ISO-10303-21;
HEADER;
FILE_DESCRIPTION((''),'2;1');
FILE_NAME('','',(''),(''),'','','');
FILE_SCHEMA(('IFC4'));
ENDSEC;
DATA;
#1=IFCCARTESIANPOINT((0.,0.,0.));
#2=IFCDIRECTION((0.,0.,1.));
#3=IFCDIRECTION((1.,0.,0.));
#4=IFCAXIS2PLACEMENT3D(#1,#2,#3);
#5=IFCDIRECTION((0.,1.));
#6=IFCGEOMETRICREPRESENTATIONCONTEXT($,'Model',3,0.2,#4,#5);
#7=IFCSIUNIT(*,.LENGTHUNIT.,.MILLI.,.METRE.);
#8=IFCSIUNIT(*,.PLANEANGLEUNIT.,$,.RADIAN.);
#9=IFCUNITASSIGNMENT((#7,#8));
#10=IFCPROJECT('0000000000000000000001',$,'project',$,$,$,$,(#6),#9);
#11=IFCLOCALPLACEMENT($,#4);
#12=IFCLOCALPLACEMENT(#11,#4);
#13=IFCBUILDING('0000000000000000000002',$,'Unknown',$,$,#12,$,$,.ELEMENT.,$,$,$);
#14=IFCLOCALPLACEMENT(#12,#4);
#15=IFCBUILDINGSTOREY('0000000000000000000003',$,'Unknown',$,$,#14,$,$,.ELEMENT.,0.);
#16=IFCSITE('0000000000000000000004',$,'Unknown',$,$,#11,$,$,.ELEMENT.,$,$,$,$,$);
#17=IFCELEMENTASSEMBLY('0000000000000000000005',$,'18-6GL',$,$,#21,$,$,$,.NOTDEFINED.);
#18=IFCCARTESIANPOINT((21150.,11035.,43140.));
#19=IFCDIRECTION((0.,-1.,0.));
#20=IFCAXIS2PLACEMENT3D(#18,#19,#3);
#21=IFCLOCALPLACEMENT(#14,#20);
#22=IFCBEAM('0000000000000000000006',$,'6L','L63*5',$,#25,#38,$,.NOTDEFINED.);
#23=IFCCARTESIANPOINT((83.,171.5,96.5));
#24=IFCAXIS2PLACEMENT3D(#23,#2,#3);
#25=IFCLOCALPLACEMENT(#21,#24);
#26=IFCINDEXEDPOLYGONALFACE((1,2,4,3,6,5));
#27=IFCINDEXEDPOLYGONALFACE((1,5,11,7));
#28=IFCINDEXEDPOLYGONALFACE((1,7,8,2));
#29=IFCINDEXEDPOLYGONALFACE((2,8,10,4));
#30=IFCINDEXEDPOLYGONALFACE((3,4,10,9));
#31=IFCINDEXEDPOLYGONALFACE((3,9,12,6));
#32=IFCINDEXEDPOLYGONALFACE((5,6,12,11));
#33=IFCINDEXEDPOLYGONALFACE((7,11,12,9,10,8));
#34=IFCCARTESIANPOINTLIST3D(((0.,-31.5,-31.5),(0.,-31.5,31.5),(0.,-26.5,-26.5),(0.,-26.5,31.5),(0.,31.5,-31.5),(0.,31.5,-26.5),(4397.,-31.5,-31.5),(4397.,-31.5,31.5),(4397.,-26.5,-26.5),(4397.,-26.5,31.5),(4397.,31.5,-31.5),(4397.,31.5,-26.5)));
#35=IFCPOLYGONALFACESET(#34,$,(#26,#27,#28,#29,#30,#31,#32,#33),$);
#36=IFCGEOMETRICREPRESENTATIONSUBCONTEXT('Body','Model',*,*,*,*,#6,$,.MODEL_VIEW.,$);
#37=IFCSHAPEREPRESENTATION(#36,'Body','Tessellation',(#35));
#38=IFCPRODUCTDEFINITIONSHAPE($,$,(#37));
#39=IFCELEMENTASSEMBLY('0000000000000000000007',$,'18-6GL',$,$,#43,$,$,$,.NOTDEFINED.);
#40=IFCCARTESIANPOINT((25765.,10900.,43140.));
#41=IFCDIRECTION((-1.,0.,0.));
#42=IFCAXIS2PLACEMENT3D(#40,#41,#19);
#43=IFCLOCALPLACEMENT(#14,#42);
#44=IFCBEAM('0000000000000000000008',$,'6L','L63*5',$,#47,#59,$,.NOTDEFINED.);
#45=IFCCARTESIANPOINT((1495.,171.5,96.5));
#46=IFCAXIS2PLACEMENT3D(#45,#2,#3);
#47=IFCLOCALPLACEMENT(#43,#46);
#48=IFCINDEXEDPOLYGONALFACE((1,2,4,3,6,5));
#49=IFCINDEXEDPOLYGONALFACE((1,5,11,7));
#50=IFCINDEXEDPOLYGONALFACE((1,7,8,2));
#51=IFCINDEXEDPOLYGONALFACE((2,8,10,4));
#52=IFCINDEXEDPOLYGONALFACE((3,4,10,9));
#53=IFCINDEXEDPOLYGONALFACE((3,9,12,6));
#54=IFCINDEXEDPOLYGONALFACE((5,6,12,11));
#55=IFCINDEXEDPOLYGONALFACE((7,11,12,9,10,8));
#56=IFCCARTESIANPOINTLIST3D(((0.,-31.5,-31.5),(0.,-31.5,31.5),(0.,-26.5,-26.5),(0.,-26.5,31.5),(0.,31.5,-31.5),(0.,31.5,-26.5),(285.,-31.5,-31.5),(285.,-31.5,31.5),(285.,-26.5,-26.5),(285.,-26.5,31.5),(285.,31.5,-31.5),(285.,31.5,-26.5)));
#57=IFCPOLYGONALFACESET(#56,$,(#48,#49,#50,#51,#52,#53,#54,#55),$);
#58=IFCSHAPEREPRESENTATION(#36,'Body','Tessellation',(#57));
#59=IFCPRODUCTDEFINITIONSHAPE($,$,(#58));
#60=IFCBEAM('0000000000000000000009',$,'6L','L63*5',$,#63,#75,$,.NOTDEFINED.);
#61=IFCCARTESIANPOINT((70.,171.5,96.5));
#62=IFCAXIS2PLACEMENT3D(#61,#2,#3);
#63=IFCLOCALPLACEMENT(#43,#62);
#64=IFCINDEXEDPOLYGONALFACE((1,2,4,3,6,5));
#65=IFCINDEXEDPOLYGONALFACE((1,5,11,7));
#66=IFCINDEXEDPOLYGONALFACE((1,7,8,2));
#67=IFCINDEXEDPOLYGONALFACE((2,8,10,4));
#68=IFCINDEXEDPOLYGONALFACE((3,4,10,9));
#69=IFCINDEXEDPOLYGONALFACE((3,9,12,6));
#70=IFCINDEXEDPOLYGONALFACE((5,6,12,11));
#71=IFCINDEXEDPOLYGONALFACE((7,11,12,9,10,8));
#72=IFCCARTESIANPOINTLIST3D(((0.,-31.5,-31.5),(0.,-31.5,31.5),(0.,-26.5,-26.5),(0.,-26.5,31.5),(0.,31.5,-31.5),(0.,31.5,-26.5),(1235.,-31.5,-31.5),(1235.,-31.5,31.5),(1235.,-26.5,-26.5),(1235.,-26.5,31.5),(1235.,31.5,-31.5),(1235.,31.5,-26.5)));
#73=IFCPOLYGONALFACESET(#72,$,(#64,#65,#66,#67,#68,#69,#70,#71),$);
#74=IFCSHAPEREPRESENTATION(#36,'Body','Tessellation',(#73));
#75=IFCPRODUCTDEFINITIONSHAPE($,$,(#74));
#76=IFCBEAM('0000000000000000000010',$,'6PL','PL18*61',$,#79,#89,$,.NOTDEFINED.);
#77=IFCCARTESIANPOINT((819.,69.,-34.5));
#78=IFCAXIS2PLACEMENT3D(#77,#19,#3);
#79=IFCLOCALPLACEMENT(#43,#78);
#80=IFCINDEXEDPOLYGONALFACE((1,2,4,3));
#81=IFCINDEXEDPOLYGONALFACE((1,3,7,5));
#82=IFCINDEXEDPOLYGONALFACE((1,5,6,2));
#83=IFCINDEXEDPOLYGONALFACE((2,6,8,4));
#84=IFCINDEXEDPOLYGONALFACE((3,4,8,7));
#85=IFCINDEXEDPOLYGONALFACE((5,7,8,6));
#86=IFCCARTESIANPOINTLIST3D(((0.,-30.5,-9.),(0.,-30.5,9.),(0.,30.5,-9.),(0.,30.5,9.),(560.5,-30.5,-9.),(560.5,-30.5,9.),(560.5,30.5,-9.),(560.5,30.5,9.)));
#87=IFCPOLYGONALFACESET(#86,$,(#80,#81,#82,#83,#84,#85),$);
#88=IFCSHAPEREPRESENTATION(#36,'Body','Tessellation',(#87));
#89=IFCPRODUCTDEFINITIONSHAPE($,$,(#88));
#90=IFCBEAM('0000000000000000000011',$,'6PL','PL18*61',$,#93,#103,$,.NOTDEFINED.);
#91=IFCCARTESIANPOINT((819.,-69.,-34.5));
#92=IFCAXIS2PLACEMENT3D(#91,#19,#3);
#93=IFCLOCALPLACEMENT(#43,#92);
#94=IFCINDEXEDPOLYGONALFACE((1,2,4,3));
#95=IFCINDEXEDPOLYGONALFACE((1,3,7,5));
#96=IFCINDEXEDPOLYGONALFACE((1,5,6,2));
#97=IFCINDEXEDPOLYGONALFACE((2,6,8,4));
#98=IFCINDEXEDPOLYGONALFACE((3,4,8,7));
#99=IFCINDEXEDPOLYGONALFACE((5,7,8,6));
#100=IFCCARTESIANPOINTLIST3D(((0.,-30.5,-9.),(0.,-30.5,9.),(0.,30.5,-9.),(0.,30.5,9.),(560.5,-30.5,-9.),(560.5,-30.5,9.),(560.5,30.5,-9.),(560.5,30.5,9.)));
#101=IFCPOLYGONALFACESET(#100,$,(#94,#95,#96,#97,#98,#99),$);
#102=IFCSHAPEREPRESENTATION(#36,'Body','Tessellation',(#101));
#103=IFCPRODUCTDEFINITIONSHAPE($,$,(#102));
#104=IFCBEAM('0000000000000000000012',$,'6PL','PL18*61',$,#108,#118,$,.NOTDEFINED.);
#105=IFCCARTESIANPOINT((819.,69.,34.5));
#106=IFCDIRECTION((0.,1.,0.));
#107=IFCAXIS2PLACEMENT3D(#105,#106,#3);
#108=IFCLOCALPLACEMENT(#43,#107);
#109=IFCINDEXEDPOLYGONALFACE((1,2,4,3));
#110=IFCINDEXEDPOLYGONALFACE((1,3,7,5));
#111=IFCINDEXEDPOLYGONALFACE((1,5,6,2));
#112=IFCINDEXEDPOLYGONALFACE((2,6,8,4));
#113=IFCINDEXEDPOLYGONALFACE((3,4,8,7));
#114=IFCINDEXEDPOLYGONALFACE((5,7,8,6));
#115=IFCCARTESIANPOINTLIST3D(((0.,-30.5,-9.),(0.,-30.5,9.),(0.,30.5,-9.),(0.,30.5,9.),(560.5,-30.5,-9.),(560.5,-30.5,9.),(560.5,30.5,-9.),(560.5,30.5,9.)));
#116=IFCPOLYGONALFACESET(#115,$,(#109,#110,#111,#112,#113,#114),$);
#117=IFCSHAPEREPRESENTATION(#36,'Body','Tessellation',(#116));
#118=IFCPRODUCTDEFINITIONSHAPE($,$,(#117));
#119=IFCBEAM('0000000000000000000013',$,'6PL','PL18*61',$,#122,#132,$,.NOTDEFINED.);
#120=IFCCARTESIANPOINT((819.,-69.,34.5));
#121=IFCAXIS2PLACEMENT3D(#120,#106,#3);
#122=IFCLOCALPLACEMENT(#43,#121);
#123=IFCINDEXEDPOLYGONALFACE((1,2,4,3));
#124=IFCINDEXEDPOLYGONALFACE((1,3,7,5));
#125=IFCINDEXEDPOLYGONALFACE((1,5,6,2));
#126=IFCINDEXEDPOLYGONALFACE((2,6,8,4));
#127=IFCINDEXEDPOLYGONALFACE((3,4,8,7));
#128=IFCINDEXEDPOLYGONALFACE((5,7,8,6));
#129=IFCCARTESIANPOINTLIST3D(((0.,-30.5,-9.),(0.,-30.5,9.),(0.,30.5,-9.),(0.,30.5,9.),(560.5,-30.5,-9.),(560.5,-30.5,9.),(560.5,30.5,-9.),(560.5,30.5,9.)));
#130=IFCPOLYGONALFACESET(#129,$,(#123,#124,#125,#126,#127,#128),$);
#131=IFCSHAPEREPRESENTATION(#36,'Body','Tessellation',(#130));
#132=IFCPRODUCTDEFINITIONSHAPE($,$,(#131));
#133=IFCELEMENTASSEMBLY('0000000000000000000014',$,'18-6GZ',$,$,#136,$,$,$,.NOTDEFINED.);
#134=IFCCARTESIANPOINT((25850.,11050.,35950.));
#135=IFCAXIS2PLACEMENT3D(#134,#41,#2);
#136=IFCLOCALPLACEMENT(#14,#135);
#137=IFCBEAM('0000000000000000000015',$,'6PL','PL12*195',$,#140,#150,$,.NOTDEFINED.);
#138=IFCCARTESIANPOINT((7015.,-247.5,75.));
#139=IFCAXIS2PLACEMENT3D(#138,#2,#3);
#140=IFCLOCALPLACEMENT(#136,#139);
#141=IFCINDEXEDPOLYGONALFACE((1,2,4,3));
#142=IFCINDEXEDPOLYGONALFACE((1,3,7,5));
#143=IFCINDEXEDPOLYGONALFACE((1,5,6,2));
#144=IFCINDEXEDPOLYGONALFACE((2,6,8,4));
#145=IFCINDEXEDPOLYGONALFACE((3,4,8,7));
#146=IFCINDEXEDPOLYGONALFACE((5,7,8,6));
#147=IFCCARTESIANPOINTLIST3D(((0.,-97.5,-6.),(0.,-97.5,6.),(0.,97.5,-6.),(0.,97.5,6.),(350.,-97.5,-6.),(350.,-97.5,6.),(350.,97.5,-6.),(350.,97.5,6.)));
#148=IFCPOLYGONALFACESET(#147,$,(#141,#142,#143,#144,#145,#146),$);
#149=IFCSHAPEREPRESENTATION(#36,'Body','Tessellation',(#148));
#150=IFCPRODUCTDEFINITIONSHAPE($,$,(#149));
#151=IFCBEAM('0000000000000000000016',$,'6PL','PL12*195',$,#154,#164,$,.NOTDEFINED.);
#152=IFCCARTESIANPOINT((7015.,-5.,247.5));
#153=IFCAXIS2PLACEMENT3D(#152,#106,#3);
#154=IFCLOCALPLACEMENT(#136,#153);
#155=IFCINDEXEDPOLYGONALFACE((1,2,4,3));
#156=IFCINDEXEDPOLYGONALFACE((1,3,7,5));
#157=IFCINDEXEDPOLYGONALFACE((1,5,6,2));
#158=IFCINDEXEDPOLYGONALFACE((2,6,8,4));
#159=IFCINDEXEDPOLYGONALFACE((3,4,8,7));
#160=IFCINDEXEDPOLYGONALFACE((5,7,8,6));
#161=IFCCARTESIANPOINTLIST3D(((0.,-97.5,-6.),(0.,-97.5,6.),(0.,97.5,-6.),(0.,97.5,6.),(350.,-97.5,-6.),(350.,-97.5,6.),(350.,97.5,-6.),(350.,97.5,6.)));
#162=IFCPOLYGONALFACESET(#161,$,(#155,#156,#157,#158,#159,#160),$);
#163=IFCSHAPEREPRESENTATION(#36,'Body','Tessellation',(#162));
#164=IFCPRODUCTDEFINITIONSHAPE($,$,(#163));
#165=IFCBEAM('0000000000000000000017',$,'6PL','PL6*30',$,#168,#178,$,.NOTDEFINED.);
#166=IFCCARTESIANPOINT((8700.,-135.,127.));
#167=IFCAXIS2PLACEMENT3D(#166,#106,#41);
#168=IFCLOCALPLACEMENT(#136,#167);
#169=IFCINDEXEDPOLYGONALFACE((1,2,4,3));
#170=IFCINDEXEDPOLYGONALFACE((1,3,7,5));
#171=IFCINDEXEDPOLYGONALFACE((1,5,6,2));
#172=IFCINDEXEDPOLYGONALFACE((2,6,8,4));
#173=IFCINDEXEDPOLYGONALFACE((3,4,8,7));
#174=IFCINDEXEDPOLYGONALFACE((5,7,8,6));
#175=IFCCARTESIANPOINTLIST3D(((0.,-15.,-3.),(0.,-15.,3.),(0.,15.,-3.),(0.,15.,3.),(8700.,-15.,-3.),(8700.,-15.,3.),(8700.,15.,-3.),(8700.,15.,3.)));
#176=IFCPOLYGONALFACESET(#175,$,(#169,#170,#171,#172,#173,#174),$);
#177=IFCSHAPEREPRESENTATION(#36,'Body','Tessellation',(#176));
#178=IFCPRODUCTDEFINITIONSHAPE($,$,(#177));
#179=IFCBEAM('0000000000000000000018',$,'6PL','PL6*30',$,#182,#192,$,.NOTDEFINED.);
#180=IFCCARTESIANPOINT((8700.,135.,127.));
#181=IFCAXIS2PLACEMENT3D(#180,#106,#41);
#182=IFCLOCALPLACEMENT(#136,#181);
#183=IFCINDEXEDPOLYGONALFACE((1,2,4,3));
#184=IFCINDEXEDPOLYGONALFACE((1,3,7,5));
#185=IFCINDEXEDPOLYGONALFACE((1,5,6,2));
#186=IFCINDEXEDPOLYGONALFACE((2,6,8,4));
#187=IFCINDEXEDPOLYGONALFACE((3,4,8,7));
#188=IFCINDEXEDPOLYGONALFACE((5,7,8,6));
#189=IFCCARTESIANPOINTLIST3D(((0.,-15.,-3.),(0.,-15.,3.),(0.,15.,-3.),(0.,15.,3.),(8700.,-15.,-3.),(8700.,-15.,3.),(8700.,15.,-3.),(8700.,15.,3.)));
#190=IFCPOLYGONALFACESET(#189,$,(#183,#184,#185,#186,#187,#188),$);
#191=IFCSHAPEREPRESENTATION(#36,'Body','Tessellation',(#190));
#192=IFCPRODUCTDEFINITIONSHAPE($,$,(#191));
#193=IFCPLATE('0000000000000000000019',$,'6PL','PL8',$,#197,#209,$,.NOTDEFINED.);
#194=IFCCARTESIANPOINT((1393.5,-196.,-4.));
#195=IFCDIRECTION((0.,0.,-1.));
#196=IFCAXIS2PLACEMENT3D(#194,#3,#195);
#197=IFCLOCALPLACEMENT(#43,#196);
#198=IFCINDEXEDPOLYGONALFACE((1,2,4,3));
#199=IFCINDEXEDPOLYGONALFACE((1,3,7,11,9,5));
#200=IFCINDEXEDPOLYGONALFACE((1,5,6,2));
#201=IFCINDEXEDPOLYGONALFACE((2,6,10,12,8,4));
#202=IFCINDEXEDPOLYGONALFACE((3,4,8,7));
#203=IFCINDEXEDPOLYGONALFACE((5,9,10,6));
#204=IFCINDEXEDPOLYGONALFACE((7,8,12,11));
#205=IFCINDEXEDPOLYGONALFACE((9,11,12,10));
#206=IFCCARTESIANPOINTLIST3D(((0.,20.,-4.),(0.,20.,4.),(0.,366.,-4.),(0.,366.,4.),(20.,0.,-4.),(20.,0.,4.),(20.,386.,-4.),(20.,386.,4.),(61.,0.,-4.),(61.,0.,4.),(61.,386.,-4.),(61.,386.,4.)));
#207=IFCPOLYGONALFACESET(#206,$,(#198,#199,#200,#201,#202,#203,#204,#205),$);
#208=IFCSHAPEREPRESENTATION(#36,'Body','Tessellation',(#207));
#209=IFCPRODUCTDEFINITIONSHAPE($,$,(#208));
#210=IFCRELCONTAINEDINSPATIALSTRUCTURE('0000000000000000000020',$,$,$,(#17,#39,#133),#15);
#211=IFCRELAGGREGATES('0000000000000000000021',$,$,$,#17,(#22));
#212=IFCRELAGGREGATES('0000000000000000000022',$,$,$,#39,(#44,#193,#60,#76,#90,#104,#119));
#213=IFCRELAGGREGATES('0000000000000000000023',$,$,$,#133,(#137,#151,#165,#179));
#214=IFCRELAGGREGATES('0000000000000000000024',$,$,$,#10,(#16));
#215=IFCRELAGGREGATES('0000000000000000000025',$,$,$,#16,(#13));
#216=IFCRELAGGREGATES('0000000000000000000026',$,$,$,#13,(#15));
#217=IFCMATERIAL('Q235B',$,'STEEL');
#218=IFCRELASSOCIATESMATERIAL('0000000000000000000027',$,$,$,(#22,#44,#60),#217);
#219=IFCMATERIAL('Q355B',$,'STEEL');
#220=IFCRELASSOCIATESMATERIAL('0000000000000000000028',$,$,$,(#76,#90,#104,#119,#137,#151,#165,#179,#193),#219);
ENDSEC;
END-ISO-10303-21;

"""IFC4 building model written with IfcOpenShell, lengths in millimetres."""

from ifc_helpers import new_model, si_unit, direction, frame, origin_with_axes, place, context, subcontext, project, spatial, line, indexed_curve, outline, extrude, material, element, aggregate, save


model = new_model("IFC4")

# Units and contexts
model_context = context("Model", 3, precision=0.2, world=origin_with_axes(), true_north=direction((0.0, 1.0)))
body_context = subcontext(model_context, "Body", "Model", "MODEL_VIEW")
ifc_project = project(units=[si_unit("LENGTHUNIT", "METRE", prefix="MILLI"), si_unit("PLANEANGLEUNIT", "RADIAN")], contexts=[model_context])

# Site, building, storey
site_placement = place(None, origin_with_axes())
site = spatial("IfcSite", under=ifc_project, at=site_placement, Name="Unknown", CompositionType="ELEMENT")
building_placement = place(site_placement, origin_with_axes())
building = spatial("IfcBuilding", under=site, at=building_placement, Name="Unknown", CompositionType="ELEMENT")
storey_placement = place(building_placement, origin_with_axes())
storey = spatial("IfcBuildingStorey", under=building, at=storey_placement, Name="Unknown", CompositionType="ELEMENT", Elevation=0.0)

# Element assembly, beam
assembly_1_placement = place(storey_placement, frame((21150.0, 11035.0, 43140.0), z_axis=(0.0, -1.0, 0.0), x_axis=(1.0, 0.0, 0.0)))
assembly_1 = element("IfcElementAssembly", 1, at=assembly_1_placement, inside=storey, Name="18-6GL", PredefinedType="NOTDEFINED")
ifc_material_1 = material(Name="Q235B", Category="STEEL")
beam_1_placement = place(assembly_1_placement, frame((83.0, 171.5, 96.5), z_axis=(0.0, 0.0, 1.0), x_axis=(1.0, 0.0, 0.0)))
beam_1 = element("IfcBeam", 2, at=beam_1_placement, material=ifc_material_1, Name="6L", Description="L63*5", PredefinedType="NOTDEFINED", context=body_context, shape_type="SolidModel", body=[
    extrude(outline(indexed_curve([(-31.5, -31.5), (31.5, -31.5), (31.5, -26.5), (-26.5, -26.5), (-26.5, 31.5), (-31.5, 31.5)], segments=[line(1, 2, 3, 4, 5, 6, 1)])), frame((0.0, 0.0, 0.0), z_axis=(-1.0, 0.0, 0.0), x_axis=(0.0, 0.0, 1.0)), (0.0, 0.0, -1.0), 4397.0),
])

# Element assembly, beams
assembly_2_placement = place(storey_placement, frame((25765.0, 10900.0, 43140.0), z_axis=(-1.0, 0.0, 0.0), x_axis=(0.0, -1.0, 0.0)))
assembly_2 = element("IfcElementAssembly", 3, at=assembly_2_placement, inside=storey, Name="18-6GL", PredefinedType="NOTDEFINED")
beam_2_placement = place(assembly_2_placement, frame((1495.0, 171.5, 96.5), z_axis=(0.0, 0.0, 1.0), x_axis=(1.0, 0.0, 0.0)))
beam_2 = element("IfcBeam", 4, at=beam_2_placement, material=ifc_material_1, Name="6L", Description="L63*5", PredefinedType="NOTDEFINED", context=body_context, shape_type="SolidModel", body=[
    extrude(outline(indexed_curve([(-31.5, -31.5), (31.5, -31.5), (31.5, -26.5), (-26.5, -26.5), (-26.5, 31.5), (-31.5, 31.5)], segments=[line(1, 2, 3, 4, 5, 6, 1)])), frame((0.0, 0.0, 0.0), z_axis=(-1.0, 0.0, 0.0), x_axis=(0.0, 0.0, 1.0)), (0.0, 0.0, -1.0), 285.0),
])
beam_3_placement = place(assembly_2_placement, frame((70.0, 171.5, 96.5), z_axis=(0.0, 0.0, 1.0), x_axis=(1.0, 0.0, 0.0)))
beam_3 = element("IfcBeam", 5, at=beam_3_placement, material=ifc_material_1, Name="6L", Description="L63*5", PredefinedType="NOTDEFINED", context=body_context, shape_type="SolidModel", body=[
    extrude(outline(indexed_curve([(-31.5, -31.5), (31.5, -31.5), (31.5, -26.5), (-26.5, -26.5), (-26.5, 31.5), (-31.5, 31.5)], segments=[line(1, 2, 3, 4, 5, 6, 1)])), frame((0.0, 0.0, 0.0), z_axis=(-1.0, 0.0, 0.0), x_axis=(0.0, 0.0, 1.0)), (0.0, 0.0, -1.0), 1235.0),
])
ifc_material_2 = material(Name="Q355B", Category="STEEL")
beam_4_placement = place(assembly_2_placement, frame((819.0, 69.0, -34.5), z_axis=(0.0, -1.0, 0.0), x_axis=(1.0, 0.0, 0.0)))
beam_4 = element("IfcBeam", 6, at=beam_4_placement, material=ifc_material_2, Name="6PL", Description="PL18*61", PredefinedType="NOTDEFINED", context=body_context, shape_type="SolidModel", body=[
    extrude(outline(indexed_curve([(-9.0, -30.5), (9.0, -30.5), (9.0, 30.5), (-9.0, 30.5)], segments=[line(1, 2, 3, 4, 1)])), frame((0.0, 0.0, 0.0), z_axis=(-1.0, 0.0, 0.0), x_axis=(0.0, 0.0, 1.0)), (0.0, 0.0, -1.0), 560.5),
])
beam_5_placement = place(assembly_2_placement, frame((819.0, -69.0, -34.5), z_axis=(0.0, -1.0, 0.0), x_axis=(1.0, 0.0, 0.0)))
beam_5 = element("IfcBeam", 7, at=beam_5_placement, material=ifc_material_2, Name="6PL", Description="PL18*61", PredefinedType="NOTDEFINED", context=body_context, shape_type="SolidModel", body=[
    extrude(outline(indexed_curve([(-9.0, -30.5), (9.0, -30.5), (9.0, 30.5), (-9.0, 30.5)], segments=[line(1, 2, 3, 4, 1)])), frame((0.0, 0.0, 0.0), z_axis=(-1.0, 0.0, 0.0), x_axis=(0.0, 0.0, 1.0)), (0.0, 0.0, -1.0), 560.5),
])
beam_6_placement = place(assembly_2_placement, frame((819.0, 69.0, 34.5), z_axis=(0.0, 1.0, 0.0), x_axis=(1.0, 0.0, 0.0)))
beam_6 = element("IfcBeam", 8, at=beam_6_placement, material=ifc_material_2, Name="6PL", Description="PL18*61", PredefinedType="NOTDEFINED", context=body_context, shape_type="SolidModel", body=[
    extrude(outline(indexed_curve([(-9.0, -30.5), (9.0, -30.5), (9.0, 30.5), (-9.0, 30.5)], segments=[line(1, 2, 3, 4, 1)])), frame((0.0, 0.0, 0.0), z_axis=(-1.0, 0.0, 0.0), x_axis=(0.0, 0.0, 1.0)), (0.0, 0.0, -1.0), 560.5),
])
beam_7_placement = place(assembly_2_placement, frame((819.0, -69.0, 34.5), z_axis=(0.0, 1.0, 0.0), x_axis=(1.0, 0.0, 0.0)))
beam_7 = element("IfcBeam", 9, at=beam_7_placement, material=ifc_material_2, Name="6PL", Description="PL18*61", PredefinedType="NOTDEFINED", context=body_context, shape_type="SolidModel", body=[
    extrude(outline(indexed_curve([(-9.0, -30.5), (9.0, -30.5), (9.0, 30.5), (-9.0, 30.5)], segments=[line(1, 2, 3, 4, 1)])), frame((0.0, 0.0, 0.0), z_axis=(-1.0, 0.0, 0.0), x_axis=(0.0, 0.0, 1.0)), (0.0, 0.0, -1.0), 560.5),
])

# Element assembly, beams
assembly_3_placement = place(storey_placement, frame((25850.0, 11050.0, 35950.0), z_axis=(-1.0, 0.0, 0.0), x_axis=(0.0, 0.0, 1.0)))
assembly_3 = element("IfcElementAssembly", 10, at=assembly_3_placement, inside=storey, Name="18-6GZ", PredefinedType="NOTDEFINED")
beam_8_placement = place(assembly_3_placement, frame((7015.0, -247.5, 75.0), z_axis=(0.0, 0.0, 1.0), x_axis=(1.0, 0.0, 0.0)))
beam_8 = element("IfcBeam", 11, at=beam_8_placement, material=ifc_material_2, Name="6PL", Description="PL12*195", PredefinedType="NOTDEFINED", context=body_context, shape_type="SolidModel", body=[
    extrude(outline(indexed_curve([(-6.0, -97.5), (6.0, -97.5), (6.0, 97.5), (-6.0, 97.5)], segments=[line(1, 2, 3, 4, 1)])), frame((0.0, 0.0, 0.0), z_axis=(-1.0, 0.0, 0.0), x_axis=(0.0, 0.0, 1.0)), (0.0, 0.0, -1.0), 350.0),
])
beam_9_placement = place(assembly_3_placement, frame((7015.0, -5.0, 247.5), z_axis=(0.0, 1.0, 0.0), x_axis=(1.0, 0.0, 0.0)))
beam_9 = element("IfcBeam", 12, at=beam_9_placement, material=ifc_material_2, Name="6PL", Description="PL12*195", PredefinedType="NOTDEFINED", context=body_context, shape_type="SolidModel", body=[
    extrude(outline(indexed_curve([(-6.0, -97.5), (6.0, -97.5), (6.0, 97.5), (-6.0, 97.5)], segments=[line(1, 2, 3, 4, 1)])), frame((0.0, 0.0, 0.0), z_axis=(-1.0, 0.0, 0.0), x_axis=(0.0, 0.0, 1.0)), (0.0, 0.0, -1.0), 350.0),
])
beam_10_placement = place(assembly_3_placement, frame((8700.0, -135.0, 127.0), z_axis=(0.0, 1.0, 0.0), x_axis=(-1.0, 0.0, 0.0)))
beam_10 = element("IfcBeam", 13, at=beam_10_placement, material=ifc_material_2, Name="6PL", Description="PL6*30", PredefinedType="NOTDEFINED", context=body_context, shape_type="SolidModel", body=[
    extrude(outline(indexed_curve([(-3.0, -15.0), (3.0, -15.0), (3.0, 15.0), (-3.0, 15.0)], segments=[line(1, 2, 3, 4, 1)])), frame((0.0, 0.0, 0.0), z_axis=(-1.0, 0.0, 0.0), x_axis=(0.0, 0.0, 1.0)), (0.0, 0.0, -1.0), 8700.0),
])
beam_11_placement = place(assembly_3_placement, frame((8700.0, 135.0, 127.0), z_axis=(0.0, 1.0, 0.0), x_axis=(-1.0, 0.0, 0.0)))
beam_11 = element("IfcBeam", 14, at=beam_11_placement, material=ifc_material_2, Name="6PL", Description="PL6*30", PredefinedType="NOTDEFINED", context=body_context, shape_type="SolidModel", body=[
    extrude(outline(indexed_curve([(-3.0, -15.0), (3.0, -15.0), (3.0, 15.0), (-3.0, 15.0)], segments=[line(1, 2, 3, 4, 1)])), frame((0.0, 0.0, 0.0), z_axis=(-1.0, 0.0, 0.0), x_axis=(0.0, 0.0, 1.0)), (0.0, 0.0, -1.0), 8700.0),
])

# Plate
aggregate(assembly_1, [beam_1])
plate_1_placement = place(assembly_2_placement, frame((1393.5, -196.0, -4.0), z_axis=(1.0, 0.0, 0.0), x_axis=(0.0, 0.0, -1.0)))
plate_1 = element("IfcPlate", 15, at=plate_1_placement, material=ifc_material_2, Name="6PL", Description="PL8", PredefinedType="NOTDEFINED", context=body_context, shape_type="SolidModel", body=[
    extrude(outline(indexed_curve([(0.0, 20.0), (20.0, 0.0), (61.0, 0.0), (61.0, 386.0), (20.0, 386.0), (0.0, 366.0)], segments=[line(1, 2, 3, 4, 5, 6, 1)])), frame((0.0, 0.0, 4.0), z_axis=(0.0, 0.0, 1.0), x_axis=(1.0, 0.0, 0.0)), (0.0, 0.0, -1.0), 8.0),
])

aggregate(assembly_2, [beam_2, plate_1, beam_3, beam_4, beam_5, beam_6, beam_7])
aggregate(assembly_3, [beam_8, beam_9, beam_10, beam_11])

save(model, "model.ifc")
